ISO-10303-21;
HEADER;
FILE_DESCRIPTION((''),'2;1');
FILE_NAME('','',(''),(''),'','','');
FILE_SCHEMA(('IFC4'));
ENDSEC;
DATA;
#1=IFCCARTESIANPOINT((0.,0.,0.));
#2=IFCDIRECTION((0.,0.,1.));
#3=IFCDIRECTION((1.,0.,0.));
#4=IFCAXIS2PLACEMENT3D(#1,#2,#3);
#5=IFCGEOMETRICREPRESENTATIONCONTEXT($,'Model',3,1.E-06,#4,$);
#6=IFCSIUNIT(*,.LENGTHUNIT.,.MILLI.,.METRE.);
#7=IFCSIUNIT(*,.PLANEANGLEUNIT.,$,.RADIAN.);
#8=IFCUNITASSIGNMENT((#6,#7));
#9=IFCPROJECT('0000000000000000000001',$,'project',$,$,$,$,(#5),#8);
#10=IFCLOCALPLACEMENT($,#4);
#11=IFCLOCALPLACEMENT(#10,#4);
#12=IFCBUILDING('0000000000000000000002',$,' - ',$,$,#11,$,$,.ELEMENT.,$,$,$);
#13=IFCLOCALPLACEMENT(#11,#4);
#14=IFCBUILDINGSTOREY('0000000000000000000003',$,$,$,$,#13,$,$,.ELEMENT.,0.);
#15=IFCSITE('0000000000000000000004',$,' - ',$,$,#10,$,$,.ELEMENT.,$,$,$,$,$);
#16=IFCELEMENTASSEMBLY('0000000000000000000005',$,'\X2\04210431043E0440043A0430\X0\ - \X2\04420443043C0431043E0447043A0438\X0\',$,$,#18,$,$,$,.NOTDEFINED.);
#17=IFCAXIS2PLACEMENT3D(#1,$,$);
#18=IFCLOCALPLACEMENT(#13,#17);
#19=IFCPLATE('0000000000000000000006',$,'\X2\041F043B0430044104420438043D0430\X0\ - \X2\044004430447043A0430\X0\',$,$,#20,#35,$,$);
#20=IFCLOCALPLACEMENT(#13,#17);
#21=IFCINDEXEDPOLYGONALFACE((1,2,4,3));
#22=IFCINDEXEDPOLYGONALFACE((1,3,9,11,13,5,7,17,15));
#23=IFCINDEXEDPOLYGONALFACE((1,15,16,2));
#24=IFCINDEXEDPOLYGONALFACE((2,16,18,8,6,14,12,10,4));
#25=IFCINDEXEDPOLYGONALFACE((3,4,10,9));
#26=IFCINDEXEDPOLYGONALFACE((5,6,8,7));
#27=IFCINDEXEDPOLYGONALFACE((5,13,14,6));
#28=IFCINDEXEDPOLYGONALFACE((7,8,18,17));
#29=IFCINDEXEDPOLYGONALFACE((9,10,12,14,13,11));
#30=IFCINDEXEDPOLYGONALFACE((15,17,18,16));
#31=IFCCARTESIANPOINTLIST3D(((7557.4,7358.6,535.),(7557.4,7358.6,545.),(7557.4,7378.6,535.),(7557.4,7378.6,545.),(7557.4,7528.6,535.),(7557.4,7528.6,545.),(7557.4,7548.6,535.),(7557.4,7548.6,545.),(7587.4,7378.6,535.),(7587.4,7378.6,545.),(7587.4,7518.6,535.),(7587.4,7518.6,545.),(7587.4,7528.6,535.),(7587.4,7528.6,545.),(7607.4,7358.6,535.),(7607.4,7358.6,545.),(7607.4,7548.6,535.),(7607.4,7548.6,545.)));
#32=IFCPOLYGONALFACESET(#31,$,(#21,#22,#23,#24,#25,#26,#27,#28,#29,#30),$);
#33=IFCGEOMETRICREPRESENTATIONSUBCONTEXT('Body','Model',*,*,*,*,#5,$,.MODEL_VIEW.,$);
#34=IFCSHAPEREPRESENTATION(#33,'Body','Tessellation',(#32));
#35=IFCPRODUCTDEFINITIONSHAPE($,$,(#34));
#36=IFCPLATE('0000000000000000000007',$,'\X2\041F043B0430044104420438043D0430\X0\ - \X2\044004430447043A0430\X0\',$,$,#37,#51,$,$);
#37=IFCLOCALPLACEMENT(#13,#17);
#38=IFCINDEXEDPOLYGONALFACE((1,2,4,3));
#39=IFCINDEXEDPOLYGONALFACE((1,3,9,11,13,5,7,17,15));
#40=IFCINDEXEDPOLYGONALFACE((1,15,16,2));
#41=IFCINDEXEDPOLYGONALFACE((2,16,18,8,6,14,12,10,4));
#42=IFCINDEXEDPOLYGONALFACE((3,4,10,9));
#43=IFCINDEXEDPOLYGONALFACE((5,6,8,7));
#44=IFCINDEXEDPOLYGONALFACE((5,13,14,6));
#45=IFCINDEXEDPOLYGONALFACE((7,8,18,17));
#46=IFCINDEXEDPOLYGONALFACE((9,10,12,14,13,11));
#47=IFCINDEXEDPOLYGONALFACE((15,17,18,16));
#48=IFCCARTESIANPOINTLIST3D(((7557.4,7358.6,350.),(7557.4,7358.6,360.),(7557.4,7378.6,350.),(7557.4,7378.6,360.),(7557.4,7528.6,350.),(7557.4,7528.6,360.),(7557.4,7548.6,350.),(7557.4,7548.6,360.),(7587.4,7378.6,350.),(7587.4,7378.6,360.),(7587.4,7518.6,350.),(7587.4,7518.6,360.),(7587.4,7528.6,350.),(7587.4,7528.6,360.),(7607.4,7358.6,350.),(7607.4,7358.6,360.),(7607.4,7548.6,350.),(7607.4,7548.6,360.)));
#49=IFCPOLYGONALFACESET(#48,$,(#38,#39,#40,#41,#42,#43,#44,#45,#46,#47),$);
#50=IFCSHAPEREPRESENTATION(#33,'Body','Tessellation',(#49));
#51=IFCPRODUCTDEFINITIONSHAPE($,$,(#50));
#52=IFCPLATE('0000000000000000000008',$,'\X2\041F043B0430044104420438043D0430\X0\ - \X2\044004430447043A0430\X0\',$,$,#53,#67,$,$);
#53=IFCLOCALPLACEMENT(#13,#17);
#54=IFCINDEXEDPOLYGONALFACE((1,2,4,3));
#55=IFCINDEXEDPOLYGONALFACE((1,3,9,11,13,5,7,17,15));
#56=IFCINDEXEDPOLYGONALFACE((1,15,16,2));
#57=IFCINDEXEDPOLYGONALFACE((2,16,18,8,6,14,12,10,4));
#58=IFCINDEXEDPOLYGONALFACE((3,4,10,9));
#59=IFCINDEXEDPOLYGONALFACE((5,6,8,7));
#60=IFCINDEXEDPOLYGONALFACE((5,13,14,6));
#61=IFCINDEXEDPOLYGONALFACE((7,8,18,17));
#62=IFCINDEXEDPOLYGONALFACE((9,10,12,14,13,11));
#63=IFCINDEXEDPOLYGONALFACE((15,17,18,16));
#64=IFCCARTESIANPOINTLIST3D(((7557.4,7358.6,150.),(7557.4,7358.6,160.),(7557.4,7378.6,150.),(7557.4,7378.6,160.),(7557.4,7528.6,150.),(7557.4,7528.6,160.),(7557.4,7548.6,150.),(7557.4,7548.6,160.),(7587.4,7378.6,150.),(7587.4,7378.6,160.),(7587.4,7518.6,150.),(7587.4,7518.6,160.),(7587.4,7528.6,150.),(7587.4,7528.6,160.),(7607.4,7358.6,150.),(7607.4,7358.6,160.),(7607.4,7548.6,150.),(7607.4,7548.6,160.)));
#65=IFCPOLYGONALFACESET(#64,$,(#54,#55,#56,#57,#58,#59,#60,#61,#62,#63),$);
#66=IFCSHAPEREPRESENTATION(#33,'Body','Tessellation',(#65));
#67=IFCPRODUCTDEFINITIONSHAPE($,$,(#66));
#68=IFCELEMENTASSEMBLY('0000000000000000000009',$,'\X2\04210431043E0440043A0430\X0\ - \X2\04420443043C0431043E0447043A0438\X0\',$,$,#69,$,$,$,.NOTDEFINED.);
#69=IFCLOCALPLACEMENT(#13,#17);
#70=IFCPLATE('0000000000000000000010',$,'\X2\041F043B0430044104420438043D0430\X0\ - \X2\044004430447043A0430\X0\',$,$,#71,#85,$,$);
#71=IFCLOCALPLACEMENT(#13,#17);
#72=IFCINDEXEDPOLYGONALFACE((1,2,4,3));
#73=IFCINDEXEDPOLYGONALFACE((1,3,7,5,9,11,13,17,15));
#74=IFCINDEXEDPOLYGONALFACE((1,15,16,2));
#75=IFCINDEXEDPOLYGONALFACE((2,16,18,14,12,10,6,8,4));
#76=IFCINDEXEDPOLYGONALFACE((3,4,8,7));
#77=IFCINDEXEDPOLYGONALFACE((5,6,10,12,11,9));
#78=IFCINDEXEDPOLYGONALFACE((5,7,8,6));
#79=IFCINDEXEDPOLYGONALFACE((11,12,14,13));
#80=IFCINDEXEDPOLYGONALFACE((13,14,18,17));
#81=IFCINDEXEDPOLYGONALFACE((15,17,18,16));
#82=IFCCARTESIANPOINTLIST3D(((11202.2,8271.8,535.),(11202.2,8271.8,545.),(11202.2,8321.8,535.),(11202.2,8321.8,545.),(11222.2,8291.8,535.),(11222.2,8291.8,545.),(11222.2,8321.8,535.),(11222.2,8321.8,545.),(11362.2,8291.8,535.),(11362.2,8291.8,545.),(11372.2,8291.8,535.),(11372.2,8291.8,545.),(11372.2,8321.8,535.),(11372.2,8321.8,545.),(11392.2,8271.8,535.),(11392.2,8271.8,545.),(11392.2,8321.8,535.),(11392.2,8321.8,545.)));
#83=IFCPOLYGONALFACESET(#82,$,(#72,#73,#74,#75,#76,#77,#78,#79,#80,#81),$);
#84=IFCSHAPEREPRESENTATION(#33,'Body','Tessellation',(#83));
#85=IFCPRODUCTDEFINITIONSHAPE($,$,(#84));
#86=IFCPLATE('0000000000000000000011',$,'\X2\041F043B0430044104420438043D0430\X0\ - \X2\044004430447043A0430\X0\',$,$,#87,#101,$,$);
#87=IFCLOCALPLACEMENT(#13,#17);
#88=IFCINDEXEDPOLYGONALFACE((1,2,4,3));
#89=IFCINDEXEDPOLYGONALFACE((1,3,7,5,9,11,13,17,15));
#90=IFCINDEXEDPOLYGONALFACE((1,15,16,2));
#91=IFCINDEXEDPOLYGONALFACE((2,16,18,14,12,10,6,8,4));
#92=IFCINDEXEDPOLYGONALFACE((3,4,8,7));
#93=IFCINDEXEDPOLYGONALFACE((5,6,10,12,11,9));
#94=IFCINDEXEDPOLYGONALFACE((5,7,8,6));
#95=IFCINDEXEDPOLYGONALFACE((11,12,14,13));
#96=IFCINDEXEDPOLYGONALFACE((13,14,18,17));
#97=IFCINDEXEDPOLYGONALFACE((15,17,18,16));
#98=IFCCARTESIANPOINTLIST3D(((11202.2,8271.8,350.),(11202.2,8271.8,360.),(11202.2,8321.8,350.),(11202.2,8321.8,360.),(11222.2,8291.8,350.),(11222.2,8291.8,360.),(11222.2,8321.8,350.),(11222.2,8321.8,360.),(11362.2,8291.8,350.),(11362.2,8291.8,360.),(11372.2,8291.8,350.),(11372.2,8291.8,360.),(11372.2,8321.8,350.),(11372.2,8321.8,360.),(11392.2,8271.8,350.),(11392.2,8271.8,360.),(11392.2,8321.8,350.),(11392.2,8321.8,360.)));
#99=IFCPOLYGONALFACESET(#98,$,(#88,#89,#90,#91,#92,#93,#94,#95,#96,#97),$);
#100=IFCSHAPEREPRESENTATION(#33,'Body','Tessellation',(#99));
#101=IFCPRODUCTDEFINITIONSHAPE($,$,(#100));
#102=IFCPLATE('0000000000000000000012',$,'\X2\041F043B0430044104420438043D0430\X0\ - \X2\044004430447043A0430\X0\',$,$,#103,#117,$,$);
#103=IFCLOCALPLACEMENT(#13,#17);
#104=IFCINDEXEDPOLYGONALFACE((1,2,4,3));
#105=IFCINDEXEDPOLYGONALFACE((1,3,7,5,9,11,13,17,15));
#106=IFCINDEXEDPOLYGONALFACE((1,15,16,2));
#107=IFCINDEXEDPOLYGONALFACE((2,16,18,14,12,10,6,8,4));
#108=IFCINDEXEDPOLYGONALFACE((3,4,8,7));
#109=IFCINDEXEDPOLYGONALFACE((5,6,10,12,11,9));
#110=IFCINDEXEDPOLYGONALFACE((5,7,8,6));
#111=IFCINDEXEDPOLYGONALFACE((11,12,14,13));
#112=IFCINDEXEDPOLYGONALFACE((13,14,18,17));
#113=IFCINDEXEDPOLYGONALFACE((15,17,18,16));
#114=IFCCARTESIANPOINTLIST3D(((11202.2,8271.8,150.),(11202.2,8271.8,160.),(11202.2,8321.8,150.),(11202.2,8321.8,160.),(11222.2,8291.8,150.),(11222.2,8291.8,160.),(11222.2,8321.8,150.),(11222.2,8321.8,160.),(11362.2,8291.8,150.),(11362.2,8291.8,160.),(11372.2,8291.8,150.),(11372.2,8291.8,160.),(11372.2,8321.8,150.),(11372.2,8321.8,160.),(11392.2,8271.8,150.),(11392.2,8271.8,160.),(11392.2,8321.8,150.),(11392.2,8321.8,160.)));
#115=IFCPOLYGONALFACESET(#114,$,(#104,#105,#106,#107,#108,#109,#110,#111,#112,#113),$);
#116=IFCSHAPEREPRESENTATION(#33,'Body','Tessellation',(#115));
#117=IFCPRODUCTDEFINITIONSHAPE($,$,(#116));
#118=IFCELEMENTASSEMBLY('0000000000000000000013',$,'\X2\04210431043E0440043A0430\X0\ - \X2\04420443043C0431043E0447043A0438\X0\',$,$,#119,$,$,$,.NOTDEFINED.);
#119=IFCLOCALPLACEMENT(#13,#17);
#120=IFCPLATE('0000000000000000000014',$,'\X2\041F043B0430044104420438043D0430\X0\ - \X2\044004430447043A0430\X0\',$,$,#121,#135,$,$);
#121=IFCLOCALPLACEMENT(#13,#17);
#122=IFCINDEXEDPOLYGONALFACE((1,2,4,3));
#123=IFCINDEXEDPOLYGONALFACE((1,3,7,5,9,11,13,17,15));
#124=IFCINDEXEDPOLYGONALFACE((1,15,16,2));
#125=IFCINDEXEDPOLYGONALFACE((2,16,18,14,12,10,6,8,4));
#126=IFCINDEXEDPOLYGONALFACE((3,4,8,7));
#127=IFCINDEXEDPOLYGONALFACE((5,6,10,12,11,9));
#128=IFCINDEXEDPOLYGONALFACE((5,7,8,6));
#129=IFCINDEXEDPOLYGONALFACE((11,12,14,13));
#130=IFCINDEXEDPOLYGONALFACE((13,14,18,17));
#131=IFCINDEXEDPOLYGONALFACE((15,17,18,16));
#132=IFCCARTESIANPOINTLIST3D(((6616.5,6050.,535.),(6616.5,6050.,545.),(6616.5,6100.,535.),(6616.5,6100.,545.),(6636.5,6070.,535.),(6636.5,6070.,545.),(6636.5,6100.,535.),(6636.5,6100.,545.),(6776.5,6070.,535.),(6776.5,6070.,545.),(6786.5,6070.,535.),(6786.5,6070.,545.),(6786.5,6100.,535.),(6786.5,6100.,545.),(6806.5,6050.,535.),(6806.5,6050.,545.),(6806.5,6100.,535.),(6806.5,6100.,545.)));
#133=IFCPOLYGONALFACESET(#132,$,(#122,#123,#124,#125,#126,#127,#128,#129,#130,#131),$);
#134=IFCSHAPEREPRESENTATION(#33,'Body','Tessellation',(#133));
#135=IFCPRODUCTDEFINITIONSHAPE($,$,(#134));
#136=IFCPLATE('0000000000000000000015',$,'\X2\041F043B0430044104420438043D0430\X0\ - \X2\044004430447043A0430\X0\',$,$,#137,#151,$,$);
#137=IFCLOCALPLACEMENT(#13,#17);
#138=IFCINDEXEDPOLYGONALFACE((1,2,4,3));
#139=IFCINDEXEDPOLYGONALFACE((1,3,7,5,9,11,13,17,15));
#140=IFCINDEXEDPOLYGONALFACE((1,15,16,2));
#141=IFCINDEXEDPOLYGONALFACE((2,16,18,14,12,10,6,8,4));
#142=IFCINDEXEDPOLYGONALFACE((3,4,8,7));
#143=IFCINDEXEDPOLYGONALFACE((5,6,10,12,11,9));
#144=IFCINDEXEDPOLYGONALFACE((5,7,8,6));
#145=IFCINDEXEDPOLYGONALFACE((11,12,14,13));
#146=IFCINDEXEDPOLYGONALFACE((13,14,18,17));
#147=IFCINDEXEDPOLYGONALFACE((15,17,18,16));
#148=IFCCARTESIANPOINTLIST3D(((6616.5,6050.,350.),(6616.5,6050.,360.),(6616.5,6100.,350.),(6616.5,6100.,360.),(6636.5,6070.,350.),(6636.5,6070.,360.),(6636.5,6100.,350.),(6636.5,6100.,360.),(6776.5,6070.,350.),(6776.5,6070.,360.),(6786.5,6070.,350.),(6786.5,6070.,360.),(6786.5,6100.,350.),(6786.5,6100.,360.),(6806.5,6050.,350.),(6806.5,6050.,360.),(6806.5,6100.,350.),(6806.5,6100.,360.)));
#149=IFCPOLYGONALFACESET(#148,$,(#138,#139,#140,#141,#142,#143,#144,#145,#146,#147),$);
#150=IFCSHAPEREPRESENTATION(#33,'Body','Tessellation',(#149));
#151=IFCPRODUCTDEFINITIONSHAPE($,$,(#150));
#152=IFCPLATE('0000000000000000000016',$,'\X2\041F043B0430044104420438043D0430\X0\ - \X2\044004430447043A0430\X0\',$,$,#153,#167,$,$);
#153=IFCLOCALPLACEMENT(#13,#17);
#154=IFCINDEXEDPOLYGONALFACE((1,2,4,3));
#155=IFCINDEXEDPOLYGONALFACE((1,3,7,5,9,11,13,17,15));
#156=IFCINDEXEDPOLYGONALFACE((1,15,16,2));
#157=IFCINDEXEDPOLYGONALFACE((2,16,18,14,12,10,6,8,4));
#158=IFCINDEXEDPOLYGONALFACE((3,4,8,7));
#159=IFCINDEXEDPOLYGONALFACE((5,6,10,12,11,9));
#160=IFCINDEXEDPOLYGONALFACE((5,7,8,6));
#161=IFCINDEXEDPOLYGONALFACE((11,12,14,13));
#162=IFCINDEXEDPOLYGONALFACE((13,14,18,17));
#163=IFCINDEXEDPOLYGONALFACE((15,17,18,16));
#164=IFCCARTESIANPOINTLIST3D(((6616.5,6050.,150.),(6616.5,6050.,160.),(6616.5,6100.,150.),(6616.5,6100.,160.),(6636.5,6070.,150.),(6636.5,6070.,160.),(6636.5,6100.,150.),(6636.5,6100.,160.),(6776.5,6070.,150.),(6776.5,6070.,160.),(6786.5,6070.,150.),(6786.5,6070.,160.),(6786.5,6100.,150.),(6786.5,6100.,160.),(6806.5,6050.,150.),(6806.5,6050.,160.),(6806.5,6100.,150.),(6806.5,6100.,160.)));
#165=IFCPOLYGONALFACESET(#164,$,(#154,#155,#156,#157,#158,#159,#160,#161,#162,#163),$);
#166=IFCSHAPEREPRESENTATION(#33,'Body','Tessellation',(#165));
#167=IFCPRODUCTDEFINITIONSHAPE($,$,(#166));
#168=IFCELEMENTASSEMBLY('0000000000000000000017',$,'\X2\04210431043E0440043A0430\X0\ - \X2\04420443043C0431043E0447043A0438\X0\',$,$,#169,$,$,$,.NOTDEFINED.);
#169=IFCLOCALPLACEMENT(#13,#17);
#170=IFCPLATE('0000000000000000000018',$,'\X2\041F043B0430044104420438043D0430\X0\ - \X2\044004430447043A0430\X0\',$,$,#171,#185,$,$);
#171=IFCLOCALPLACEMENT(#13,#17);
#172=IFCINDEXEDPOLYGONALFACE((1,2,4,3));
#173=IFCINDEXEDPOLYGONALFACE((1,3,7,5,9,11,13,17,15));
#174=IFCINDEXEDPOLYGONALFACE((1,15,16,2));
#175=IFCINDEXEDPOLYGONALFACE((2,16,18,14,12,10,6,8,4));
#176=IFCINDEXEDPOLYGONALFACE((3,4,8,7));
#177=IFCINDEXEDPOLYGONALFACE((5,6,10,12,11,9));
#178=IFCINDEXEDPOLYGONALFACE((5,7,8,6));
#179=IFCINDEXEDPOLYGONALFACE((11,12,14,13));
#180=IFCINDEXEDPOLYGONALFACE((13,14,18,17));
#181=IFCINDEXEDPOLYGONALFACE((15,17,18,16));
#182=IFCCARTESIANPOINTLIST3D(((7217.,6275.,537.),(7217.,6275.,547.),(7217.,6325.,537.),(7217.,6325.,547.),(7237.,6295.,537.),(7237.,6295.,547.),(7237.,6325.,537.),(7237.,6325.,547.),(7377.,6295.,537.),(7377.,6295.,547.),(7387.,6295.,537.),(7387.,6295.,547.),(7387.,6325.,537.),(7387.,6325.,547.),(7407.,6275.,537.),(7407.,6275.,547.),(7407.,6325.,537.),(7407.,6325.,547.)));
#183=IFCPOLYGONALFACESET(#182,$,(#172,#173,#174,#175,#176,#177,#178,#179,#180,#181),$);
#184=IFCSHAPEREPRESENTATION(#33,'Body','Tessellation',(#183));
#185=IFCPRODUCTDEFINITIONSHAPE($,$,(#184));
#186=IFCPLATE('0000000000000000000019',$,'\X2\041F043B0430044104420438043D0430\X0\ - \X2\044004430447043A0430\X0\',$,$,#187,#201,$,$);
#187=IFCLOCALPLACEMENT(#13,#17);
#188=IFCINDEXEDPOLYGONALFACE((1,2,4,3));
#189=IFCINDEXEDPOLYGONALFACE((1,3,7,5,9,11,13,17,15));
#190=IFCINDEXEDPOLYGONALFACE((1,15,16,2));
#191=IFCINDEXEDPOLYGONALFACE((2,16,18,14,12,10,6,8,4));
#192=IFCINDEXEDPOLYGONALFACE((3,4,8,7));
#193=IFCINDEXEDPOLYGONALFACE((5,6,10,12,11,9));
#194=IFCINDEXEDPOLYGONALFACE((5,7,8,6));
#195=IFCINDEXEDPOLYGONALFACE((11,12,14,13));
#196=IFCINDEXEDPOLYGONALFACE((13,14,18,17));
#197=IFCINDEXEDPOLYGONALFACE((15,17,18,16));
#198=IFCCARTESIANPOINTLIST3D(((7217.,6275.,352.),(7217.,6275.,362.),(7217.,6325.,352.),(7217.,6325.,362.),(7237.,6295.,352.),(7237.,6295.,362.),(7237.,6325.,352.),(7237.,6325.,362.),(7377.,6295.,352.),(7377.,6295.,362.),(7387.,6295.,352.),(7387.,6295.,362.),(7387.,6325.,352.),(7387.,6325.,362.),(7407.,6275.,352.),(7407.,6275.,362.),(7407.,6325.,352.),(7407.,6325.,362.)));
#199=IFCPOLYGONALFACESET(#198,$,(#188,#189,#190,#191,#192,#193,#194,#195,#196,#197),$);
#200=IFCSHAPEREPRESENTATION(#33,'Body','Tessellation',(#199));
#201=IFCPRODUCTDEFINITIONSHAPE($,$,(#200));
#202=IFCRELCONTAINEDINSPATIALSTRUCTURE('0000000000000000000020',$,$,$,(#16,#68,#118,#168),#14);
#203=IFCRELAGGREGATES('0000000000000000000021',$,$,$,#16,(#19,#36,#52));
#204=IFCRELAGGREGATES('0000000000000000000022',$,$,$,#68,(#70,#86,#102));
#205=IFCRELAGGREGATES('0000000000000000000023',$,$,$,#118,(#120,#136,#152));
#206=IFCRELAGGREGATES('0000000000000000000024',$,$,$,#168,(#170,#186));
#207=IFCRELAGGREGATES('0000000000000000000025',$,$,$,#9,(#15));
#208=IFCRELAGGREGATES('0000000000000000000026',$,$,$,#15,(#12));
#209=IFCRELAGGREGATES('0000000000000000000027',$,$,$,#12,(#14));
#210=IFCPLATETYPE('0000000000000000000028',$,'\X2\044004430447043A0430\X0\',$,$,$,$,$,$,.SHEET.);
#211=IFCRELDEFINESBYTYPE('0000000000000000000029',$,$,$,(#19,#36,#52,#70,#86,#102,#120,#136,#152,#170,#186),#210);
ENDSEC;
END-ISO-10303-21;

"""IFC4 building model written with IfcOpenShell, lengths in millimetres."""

from ifc_helpers import new_model, si_unit, frame, origin_with_axes, place, context, subcontext, project, spatial, line, indexed_curve, outline, extrude, source, transform, mapped, type_object, element, aggregate, save


model = new_model("IFC4")

# Units and contexts
model_context = context("Model", 3, precision=1e-06, world=origin_with_axes())
body_context = subcontext(model_context, "Body", "Model", "MODEL_VIEW")
ifc_project = project(units=[si_unit("LENGTHUNIT", "METRE", prefix="MILLI"), si_unit("PLANEANGLEUNIT", "RADIAN")], contexts=[model_context])

# Site, building, storey
site_placement = place(None, origin_with_axes())
site = spatial("IfcSite", under=ifc_project, at=site_placement, Name=" - ", CompositionType="ELEMENT")
building_placement = place(site_placement, origin_with_axes())
building = spatial("IfcBuilding", under=site, at=building_placement, Name=" - ", CompositionType="ELEMENT")
storey_placement = place(building_placement, origin_with_axes())
storey = spatial("IfcBuildingStorey", under=building, at=storey_placement, CompositionType="ELEMENT", Elevation=0.0)

# Element assemblies, plates
plate_type = type_object("IfcPlateType", Name="ручка", PredefinedType="SHEET")
shared_shape_1 = source(origin_with_axes(), body_context, "Body", "SweptSolid", [
    extrude(outline(indexed_curve([(-95.0, -25.0), (-75.0, -25.0), (-75.0, 5.0), (-65.0, 5.0), (75.0, 5.0), (75.0, -25.0), (95.0, -25.0), (95.0, 25.0), (-95.0, 25.0)], segments=[line(1, 2), line(2, 3), line(3, 4), line(4, 5), line(5, 6), line(6, 7), line(7, 8), line(8, 9), line(9, 1)])), origin_with_axes(), (0.0, 0.0, 1.0), 10.0),
])
assembly_1_placement = place(storey_placement, frame((7557.4, 7253.6, 0.0), z_axis=(0.0, 0.0, 1.0), x_axis=(0.0, 1.0, 0.0)))
assembly_1 = element("IfcElementAssembly", 1, at=assembly_1_placement, inside=storey, Name="Сборка - тумбочки", PredefinedType="NOTDEFINED")
plate_1_placement = place(assembly_1_placement, frame((200.0, -25.0, 535.0), z_axis=(0.0, 0.0, 1.0), x_axis=(-1.0, 0.0, 0.0)))
plate_1 = element("IfcPlate", 2, at=plate_1_placement, type_object=plate_type, Name="Пластина - ручка", context=body_context, shape_type="MappedRepresentation", body=[
    mapped(shared_shape_1, transform((0.0, 0.0, 0.0), x_axis=(1.0, 0.0, 0.0), y_axis=(0.0, 1.0, 0.0), z_axis=(0.0, 0.0, 1.0), scale=1.0)),
])
plate_2_placement = place(assembly_1_placement, frame((200.0, -25.0, 350.0), z_axis=(0.0, 0.0, 1.0), x_axis=(-1.0, 0.0, 0.0)))
plate_2 = element("IfcPlate", 3, at=plate_2_placement, type_object=plate_type, Name="Пластина - ручка", context=body_context, shape_type="MappedRepresentation", body=[
    mapped(shared_shape_1, transform((0.0, 0.0, 0.0), x_axis=(1.0, 0.0, 0.0), y_axis=(0.0, 1.0, 0.0), z_axis=(0.0, 0.0, 1.0), scale=1.0)),
])
plate_3_placement = place(assembly_1_placement, frame((200.0, -25.0, 150.0), z_axis=(0.0, 0.0, 1.0), x_axis=(-1.0, 0.0, 0.0)))
plate_3 = element("IfcPlate", 4, at=plate_3_placement, type_object=plate_type, Name="Пластина - ручка", context=body_context, shape_type="MappedRepresentation", body=[
    mapped(shared_shape_1, transform((0.0, 0.0, 0.0), x_axis=(1.0, 0.0, 0.0), y_axis=(0.0, 1.0, 0.0), z_axis=(0.0, 0.0, 1.0), scale=1.0)),
])
aggregate(assembly_1, [plate_1, plate_2, plate_3])
assembly_2_placement = place(storey_placement, frame((11097.2, 8321.8, 0.0), z_axis=(0.0, 0.0, 1.0), x_axis=(1.0, 0.0, 0.0)))
assembly_2 = element("IfcElementAssembly", 5, at=assembly_2_placement, inside=storey, Name="Сборка - тумбочки", PredefinedType="NOTDEFINED")
plate_4_placement = place(assembly_2_placement, frame((200.0, -25.0, 535.0), z_axis=(0.0, 0.0, 1.0), x_axis=(-1.0, 0.0, 0.0)))
plate_4 = element("IfcPlate", 6, at=plate_4_placement, type_object=plate_type, Name="Пластина - ручка", context=body_context, shape_type="MappedRepresentation", body=[
    mapped(shared_shape_1, transform((0.0, 0.0, 0.0), x_axis=(1.0, 0.0, 0.0), y_axis=(0.0, 1.0, 0.0), z_axis=(0.0, 0.0, 1.0), scale=1.0)),
])
plate_5_placement = place(assembly_2_placement, frame((200.0, -25.0, 350.0), z_axis=(0.0, 0.0, 1.0), x_axis=(-1.0, 0.0, 0.0)))
plate_5 = element("IfcPlate", 7, at=plate_5_placement, type_object=plate_type, Name="Пластина - ручка", context=body_context, shape_type="MappedRepresentation", body=[
    mapped(shared_shape_1, transform((0.0, 0.0, 0.0), x_axis=(1.0, 0.0, 0.0), y_axis=(0.0, 1.0, 0.0), z_axis=(0.0, 0.0, 1.0), scale=1.0)),
])
plate_6_placement = place(assembly_2_placement, frame((200.0, -25.0, 150.0), z_axis=(0.0, 0.0, 1.0), x_axis=(-1.0, 0.0, 0.0)))
plate_6 = element("IfcPlate", 8, at=plate_6_placement, type_object=plate_type, Name="Пластина - ручка", context=body_context, shape_type="MappedRepresentation", body=[
    mapped(shared_shape_1, transform((0.0, 0.0, 0.0), x_axis=(1.0, 0.0, 0.0), y_axis=(0.0, 1.0, 0.0), z_axis=(0.0, 0.0, 1.0), scale=1.0)),
])
aggregate(assembly_2, [plate_4, plate_5, plate_6])
assembly_3_placement = place(storey_placement, frame((6511.5, 6100.0, 0.0), z_axis=(0.0, 0.0, 1.0), x_axis=(1.0, 0.0, 0.0)))
assembly_3 = element("IfcElementAssembly", 9, at=assembly_3_placement, inside=storey, Name="Сборка - тумбочки", PredefinedType="NOTDEFINED")
plate_7_placement = place(assembly_3_placement, frame((200.0, -25.0, 535.0), z_axis=(0.0, 0.0, 1.0), x_axis=(-1.0, 0.0, 0.0)))
plate_7 = element("IfcPlate", 10, at=plate_7_placement, type_object=plate_type, Name="Пластина - ручка", context=body_context, shape_type="MappedRepresentation", body=[
    mapped(shared_shape_1, transform((0.0, 0.0, 0.0), x_axis=(1.0, 0.0, 0.0), y_axis=(0.0, 1.0, 0.0), z_axis=(0.0, 0.0, 1.0), scale=1.0)),
])
plate_8_placement = place(assembly_3_placement, frame((200.0, -25.0, 350.0), z_axis=(0.0, 0.0, 1.0), x_axis=(-1.0, 0.0, 0.0)))
plate_8 = element("IfcPlate", 11, at=plate_8_placement, type_object=plate_type, Name="Пластина - ручка", context=body_context, shape_type="MappedRepresentation", body=[
    mapped(shared_shape_1, transform((0.0, 0.0, 0.0), x_axis=(1.0, 0.0, 0.0), y_axis=(0.0, 1.0, 0.0), z_axis=(0.0, 0.0, 1.0), scale=1.0)),
])
plate_9_placement = place(assembly_3_placement, frame((200.0, -25.0, 150.0), z_axis=(0.0, 0.0, 1.0), x_axis=(-1.0, 0.0, 0.0)))
plate_9 = element("IfcPlate", 12, at=plate_9_placement, type_object=plate_type, Name="Пластина - ручка", context=body_context, shape_type="MappedRepresentation", body=[
    mapped(shared_shape_1, transform((0.0, 0.0, 0.0), x_axis=(1.0, 0.0, 0.0), y_axis=(0.0, 1.0, 0.0), z_axis=(0.0, 0.0, 1.0), scale=1.0)),
])
aggregate(assembly_3, [plate_7, plate_8, plate_9])
assembly_4_placement = place(storey_placement, frame((7112.0, 6325.0, 2.0), z_axis=(0.0, 0.0, 1.0), x_axis=(1.0, 0.0, 0.0)))
assembly_4 = element("IfcElementAssembly", 13, at=assembly_4_placement, inside=storey, Name="Сборка - тумбочки", PredefinedType="NOTDEFINED")
plate_10_placement = place(assembly_4_placement, frame((200.0, -25.0, 535.0), z_axis=(0.0, 0.0, 1.0), x_axis=(-1.0, 0.0, 0.0)))
plate_10 = element("IfcPlate", 14, at=plate_10_placement, type_object=plate_type, Name="Пластина - ручка", context=body_context, shape_type="MappedRepresentation", body=[
    mapped(shared_shape_1, transform((0.0, 0.0, 0.0), x_axis=(1.0, 0.0, 0.0), y_axis=(0.0, 1.0, 0.0), z_axis=(0.0, 0.0, 1.0), scale=1.0)),
])
plate_11_placement = place(assembly_4_placement, frame((200.0, -25.0, 350.0), z_axis=(0.0, 0.0, 1.0), x_axis=(-1.0, 0.0, 0.0)))
plate_11 = element("IfcPlate", 15, at=plate_11_placement, type_object=plate_type, Name="Пластина - ручка", context=body_context, shape_type="MappedRepresentation", body=[
    mapped(shared_shape_1, transform((0.0, 0.0, 0.0), x_axis=(1.0, 0.0, 0.0), y_axis=(0.0, 1.0, 0.0), z_axis=(0.0, 0.0, 1.0), scale=1.0)),
])
aggregate(assembly_4, [plate_10, plate_11])

save(model, "model.ifc")
